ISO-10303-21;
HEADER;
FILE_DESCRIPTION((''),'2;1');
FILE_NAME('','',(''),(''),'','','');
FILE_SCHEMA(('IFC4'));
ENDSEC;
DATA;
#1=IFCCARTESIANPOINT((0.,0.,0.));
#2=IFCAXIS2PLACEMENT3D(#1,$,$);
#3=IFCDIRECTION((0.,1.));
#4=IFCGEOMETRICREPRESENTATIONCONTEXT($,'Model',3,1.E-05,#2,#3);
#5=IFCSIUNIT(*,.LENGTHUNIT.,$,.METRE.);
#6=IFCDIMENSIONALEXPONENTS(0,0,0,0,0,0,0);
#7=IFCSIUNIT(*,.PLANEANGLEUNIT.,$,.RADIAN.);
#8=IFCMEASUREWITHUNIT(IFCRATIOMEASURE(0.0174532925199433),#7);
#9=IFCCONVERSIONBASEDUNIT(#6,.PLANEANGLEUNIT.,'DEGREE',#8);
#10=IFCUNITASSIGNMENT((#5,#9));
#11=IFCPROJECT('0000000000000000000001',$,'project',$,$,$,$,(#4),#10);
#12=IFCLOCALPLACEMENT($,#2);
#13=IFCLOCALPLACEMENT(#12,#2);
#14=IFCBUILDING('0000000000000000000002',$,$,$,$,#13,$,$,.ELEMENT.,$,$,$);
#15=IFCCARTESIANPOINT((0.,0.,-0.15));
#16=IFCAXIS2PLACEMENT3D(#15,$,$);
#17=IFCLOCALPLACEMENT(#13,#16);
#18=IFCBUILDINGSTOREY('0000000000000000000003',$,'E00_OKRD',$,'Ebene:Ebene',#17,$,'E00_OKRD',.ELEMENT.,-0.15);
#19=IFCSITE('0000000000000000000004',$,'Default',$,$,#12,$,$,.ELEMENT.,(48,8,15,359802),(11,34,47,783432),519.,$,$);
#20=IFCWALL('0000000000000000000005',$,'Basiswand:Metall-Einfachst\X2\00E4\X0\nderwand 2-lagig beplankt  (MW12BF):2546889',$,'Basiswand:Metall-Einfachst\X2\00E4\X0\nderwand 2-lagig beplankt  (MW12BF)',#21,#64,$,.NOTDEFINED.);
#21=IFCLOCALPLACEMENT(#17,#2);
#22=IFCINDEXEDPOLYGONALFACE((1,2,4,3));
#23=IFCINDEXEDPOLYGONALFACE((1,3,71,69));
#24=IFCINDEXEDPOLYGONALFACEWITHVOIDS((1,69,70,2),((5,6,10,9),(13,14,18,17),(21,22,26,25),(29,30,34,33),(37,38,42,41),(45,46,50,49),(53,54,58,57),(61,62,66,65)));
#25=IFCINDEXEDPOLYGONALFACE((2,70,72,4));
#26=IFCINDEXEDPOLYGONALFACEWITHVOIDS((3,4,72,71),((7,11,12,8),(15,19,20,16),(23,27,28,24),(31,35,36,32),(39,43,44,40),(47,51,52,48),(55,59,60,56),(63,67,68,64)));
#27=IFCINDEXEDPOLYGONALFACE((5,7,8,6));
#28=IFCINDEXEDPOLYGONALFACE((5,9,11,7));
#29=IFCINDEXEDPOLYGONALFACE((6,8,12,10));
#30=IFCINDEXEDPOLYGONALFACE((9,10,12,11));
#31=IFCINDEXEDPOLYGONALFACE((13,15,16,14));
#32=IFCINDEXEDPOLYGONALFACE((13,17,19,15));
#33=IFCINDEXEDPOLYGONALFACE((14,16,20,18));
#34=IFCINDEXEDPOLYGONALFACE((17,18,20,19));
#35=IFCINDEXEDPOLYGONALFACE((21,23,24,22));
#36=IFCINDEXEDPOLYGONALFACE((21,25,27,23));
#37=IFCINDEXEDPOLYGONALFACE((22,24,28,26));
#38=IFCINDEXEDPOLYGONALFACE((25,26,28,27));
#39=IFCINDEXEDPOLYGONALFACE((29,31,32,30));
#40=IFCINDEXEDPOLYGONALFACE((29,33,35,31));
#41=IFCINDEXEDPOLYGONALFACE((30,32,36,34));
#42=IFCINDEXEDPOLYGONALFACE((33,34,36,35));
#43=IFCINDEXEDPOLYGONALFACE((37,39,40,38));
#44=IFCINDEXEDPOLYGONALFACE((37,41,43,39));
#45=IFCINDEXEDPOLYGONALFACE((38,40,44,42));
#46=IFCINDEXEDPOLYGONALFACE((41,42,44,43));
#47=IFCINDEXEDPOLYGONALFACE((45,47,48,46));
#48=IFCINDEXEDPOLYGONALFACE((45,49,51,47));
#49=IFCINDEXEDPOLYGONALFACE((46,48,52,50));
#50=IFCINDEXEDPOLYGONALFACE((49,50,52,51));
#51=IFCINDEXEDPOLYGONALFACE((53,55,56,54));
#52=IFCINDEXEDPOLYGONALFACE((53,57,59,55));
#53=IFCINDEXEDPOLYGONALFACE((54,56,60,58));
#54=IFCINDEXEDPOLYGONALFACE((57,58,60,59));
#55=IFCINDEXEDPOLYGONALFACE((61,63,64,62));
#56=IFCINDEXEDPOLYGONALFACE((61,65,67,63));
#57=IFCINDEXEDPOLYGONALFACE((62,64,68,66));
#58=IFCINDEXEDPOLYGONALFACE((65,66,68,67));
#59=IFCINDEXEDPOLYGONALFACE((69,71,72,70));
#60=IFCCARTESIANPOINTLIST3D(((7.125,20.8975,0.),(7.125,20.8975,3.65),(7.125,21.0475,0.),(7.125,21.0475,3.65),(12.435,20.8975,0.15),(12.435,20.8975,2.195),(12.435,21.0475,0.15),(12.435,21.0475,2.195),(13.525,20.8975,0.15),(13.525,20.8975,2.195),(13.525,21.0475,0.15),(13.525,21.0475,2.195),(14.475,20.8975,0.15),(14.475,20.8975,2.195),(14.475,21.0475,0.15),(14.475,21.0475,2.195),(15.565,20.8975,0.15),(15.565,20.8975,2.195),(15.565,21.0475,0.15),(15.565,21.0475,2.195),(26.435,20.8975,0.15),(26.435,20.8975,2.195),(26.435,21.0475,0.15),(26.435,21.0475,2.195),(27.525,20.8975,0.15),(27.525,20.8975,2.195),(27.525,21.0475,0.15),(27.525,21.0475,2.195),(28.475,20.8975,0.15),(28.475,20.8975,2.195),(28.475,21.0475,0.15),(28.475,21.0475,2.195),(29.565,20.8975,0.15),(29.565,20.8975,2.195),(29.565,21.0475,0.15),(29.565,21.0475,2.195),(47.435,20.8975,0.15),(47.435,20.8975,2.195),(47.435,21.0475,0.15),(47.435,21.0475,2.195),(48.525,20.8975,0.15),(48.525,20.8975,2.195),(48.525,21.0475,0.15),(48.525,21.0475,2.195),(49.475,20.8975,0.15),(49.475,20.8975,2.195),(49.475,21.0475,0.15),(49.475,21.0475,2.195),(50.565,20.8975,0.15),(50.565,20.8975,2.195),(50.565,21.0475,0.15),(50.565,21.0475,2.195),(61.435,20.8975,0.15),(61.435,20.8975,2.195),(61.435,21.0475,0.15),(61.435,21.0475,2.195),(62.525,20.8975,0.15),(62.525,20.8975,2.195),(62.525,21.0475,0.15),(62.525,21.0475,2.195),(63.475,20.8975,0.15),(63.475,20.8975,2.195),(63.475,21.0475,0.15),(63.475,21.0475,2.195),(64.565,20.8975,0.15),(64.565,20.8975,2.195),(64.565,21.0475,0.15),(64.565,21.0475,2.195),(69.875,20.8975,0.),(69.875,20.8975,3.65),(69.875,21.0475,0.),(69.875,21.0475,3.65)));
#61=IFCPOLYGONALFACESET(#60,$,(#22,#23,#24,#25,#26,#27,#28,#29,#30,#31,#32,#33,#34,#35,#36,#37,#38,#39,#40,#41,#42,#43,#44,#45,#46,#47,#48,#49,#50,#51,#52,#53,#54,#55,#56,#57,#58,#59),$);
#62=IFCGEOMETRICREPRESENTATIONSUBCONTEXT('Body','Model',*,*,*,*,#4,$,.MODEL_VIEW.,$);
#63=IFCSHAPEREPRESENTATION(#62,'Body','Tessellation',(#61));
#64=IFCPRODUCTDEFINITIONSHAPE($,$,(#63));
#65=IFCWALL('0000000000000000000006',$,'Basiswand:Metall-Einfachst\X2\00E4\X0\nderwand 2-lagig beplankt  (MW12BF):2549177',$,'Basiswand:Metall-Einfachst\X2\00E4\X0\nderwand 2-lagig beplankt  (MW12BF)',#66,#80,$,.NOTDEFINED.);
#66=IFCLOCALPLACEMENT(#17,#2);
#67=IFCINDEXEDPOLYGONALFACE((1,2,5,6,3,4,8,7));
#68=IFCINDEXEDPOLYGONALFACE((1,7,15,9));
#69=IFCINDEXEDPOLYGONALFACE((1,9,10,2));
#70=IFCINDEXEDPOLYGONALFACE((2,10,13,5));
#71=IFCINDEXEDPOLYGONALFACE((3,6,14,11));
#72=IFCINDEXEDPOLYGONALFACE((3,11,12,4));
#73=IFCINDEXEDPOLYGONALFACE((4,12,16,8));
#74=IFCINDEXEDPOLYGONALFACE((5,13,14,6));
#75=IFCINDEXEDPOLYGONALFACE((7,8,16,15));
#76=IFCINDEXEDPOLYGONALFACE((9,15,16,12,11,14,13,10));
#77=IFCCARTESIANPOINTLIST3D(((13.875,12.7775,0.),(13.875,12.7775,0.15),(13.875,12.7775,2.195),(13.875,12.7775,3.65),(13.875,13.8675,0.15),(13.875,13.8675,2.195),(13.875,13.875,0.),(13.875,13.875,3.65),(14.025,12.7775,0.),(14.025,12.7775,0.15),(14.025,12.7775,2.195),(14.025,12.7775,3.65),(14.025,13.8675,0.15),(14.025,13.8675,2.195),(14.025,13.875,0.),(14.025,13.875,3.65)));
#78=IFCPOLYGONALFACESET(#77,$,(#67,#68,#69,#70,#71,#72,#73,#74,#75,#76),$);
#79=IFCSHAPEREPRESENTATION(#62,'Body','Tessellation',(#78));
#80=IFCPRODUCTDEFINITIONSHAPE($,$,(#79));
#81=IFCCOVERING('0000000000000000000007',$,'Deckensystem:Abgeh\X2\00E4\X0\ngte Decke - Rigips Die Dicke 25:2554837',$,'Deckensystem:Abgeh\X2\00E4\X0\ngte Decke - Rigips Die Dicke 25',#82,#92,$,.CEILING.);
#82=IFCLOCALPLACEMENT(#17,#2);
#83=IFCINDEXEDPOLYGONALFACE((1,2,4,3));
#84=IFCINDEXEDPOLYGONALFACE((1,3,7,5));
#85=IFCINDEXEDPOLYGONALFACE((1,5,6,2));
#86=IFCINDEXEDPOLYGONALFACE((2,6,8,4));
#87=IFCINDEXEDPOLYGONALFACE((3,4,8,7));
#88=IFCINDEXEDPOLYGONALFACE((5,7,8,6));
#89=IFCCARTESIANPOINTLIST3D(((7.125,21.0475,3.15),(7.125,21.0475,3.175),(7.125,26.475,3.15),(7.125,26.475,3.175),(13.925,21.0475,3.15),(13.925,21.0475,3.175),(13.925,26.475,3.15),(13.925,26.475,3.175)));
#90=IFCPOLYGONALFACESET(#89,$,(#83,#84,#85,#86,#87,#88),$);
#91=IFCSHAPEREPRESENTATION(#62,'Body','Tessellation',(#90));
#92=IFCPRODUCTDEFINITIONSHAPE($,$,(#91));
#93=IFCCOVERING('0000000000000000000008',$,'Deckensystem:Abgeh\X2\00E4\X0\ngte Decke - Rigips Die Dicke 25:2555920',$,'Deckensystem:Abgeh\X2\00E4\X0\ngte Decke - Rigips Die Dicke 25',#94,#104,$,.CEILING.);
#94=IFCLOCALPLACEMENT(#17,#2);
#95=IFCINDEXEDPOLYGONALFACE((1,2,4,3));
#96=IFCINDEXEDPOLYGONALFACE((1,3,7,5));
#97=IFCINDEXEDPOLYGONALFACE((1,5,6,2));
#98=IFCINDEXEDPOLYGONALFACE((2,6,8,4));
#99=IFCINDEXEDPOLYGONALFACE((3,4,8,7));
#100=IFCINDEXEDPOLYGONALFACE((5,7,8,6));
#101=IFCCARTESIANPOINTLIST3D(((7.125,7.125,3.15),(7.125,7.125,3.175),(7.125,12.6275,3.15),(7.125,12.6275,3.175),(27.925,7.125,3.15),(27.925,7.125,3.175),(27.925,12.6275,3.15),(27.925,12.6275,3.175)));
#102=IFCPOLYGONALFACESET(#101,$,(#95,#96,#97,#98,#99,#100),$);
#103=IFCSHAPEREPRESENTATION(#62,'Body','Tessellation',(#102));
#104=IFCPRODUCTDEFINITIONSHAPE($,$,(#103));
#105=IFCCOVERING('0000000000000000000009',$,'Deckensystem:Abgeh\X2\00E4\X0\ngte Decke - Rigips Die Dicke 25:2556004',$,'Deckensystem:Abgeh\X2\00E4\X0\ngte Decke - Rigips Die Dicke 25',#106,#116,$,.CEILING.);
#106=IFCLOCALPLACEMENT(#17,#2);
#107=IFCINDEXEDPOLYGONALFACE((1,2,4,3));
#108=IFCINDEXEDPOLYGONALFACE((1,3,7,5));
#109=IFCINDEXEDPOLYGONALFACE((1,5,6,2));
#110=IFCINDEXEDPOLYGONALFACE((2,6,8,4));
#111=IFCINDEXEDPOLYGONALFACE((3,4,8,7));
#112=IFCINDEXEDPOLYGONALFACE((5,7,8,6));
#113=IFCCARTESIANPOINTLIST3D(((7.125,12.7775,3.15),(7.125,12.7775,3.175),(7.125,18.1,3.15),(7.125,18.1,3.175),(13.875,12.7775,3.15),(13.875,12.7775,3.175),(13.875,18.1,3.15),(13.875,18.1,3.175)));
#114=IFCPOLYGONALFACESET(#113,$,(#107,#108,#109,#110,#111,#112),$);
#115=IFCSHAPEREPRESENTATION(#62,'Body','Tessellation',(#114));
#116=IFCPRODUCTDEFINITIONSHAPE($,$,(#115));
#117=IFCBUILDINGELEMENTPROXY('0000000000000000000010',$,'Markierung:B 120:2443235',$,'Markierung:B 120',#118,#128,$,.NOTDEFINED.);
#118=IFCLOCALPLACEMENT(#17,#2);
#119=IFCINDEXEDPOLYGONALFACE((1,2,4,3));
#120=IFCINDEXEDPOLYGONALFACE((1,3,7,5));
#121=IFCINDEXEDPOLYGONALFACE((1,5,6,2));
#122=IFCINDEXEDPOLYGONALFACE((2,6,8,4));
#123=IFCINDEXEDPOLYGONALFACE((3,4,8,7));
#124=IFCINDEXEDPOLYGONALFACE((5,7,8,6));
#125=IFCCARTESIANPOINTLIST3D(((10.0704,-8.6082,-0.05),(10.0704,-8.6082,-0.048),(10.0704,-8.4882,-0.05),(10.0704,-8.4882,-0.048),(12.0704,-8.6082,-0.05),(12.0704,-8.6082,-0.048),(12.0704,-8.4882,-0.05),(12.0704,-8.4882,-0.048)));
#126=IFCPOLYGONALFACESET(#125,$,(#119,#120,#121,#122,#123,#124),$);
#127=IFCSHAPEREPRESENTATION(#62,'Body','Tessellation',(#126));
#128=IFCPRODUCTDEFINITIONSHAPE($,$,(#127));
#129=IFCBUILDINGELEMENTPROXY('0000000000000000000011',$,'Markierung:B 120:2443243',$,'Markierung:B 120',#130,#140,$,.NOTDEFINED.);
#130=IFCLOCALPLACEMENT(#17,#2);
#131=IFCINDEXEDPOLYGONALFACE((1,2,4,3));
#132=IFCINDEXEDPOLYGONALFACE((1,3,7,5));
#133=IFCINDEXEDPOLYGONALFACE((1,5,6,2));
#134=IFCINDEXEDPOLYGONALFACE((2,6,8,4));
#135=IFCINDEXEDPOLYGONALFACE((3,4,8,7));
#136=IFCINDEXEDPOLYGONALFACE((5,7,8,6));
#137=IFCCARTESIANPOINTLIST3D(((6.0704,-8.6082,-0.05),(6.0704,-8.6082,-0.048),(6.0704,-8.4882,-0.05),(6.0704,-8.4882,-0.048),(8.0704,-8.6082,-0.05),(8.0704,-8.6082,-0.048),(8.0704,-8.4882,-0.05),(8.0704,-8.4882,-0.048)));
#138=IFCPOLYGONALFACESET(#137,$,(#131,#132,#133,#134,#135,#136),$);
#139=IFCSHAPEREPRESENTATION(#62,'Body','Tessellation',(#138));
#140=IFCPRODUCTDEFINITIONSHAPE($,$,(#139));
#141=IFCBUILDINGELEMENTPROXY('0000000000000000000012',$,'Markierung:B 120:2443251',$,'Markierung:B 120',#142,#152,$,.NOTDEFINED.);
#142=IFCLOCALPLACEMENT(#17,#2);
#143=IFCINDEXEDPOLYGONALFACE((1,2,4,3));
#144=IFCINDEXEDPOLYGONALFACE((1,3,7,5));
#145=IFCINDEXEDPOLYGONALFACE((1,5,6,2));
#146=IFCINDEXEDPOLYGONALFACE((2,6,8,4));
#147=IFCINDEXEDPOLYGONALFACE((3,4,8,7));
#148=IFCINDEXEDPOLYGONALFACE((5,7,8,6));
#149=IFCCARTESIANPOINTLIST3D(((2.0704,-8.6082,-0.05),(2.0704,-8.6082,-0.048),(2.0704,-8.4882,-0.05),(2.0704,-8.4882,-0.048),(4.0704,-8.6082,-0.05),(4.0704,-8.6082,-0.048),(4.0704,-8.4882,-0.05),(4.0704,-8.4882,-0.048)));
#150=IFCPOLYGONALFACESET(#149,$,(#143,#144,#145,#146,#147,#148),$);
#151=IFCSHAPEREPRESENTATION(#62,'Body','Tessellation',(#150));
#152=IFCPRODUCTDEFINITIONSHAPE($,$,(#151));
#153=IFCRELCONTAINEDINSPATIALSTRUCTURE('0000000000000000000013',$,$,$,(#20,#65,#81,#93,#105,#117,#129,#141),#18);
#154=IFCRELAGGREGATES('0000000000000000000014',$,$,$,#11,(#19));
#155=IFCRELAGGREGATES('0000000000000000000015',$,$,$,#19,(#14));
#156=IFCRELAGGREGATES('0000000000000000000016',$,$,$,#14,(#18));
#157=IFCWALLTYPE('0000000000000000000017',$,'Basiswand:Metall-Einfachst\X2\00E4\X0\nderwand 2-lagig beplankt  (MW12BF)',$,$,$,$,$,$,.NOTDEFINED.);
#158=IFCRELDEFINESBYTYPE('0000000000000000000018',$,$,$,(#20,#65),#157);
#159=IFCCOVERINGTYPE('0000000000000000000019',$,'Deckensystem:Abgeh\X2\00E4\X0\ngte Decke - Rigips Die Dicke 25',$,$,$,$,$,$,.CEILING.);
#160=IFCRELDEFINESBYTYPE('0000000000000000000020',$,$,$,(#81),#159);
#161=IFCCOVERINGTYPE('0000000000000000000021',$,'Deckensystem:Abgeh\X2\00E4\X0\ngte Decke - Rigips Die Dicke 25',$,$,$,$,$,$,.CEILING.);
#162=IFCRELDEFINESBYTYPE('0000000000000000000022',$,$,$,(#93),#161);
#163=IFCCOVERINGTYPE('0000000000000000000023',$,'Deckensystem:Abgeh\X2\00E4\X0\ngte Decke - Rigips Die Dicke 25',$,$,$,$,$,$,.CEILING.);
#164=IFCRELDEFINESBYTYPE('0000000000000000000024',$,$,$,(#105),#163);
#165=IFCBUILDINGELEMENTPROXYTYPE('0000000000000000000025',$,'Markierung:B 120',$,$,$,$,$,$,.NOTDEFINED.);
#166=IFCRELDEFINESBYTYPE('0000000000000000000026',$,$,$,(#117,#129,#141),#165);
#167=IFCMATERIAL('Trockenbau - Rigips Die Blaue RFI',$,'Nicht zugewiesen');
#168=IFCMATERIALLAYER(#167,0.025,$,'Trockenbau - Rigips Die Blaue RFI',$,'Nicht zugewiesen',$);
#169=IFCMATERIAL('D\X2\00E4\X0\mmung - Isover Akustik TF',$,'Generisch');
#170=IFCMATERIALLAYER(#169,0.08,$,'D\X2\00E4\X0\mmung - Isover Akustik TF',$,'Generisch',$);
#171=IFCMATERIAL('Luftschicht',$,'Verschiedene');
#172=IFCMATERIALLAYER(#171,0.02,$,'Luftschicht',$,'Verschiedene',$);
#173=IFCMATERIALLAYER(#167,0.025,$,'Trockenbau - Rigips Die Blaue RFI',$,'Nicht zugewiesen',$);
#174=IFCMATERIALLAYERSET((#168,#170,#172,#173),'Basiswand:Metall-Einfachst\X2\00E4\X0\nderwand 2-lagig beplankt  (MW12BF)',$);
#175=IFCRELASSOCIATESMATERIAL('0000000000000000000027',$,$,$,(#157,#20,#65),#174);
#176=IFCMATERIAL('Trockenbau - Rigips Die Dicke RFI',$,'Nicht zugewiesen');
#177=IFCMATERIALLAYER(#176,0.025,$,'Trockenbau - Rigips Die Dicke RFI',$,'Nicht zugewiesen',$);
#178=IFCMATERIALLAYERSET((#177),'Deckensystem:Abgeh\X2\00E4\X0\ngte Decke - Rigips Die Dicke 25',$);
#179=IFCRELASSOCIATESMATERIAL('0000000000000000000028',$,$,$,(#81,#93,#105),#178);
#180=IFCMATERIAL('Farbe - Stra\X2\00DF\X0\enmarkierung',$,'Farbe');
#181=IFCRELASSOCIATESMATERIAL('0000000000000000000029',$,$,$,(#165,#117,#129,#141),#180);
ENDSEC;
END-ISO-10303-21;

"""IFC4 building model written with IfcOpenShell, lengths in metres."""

from ifc_helpers import new_model, entity, si_unit, converted_unit, direction, frame, frame_2d, origin, place, context, subcontext, project, spatial, rectangle, extrude, source, transform, mapped, material, layer, layer_set, layer_usage, type_object, type_shapes, element, save


model = new_model("IFC4")

# Units and contexts
model_context = context("Model", 3, precision=1e-05, world=origin(), true_north=direction((0.0, 1.0)))
body_context = subcontext(model_context, "Body", "Model", "MODEL_VIEW")
ifc_project = project(units=[si_unit("LENGTHUNIT", "METRE"), converted_unit("PLANEANGLEUNIT", "DEGREE", entity("IfcRatioMeasure", 0.0174532925199433), si_unit("PLANEANGLEUNIT", "RADIAN"), dimensions=[0, 0, 0, 0, 0, 0, 0])], contexts=[model_context])

# Site, building, storey
site_placement = place(None, frame((0.0, 0.0, 0.0)))
site = spatial("IfcSite", under=ifc_project, at=site_placement, Name="Default", CompositionType="ELEMENT", RefLatitude=(48, 8, 15, 359802), RefLongitude=(11, 34, 47, 783432), RefElevation=519.0)
building_placement = place(site_placement, origin())
building = spatial("IfcBuilding", under=site, at=building_placement, CompositionType="ELEMENT")
storey_placement = place(building_placement, frame((0.0, 0.0, -0.15)))
storey = spatial("IfcBuildingStorey", under=building, at=storey_placement, Name="E00_OKRD", ObjectType="Ebene:Ebene", LongName="E00_OKRD", CompositionType="ELEMENT", Elevation=-0.15)

# Wall, openings
ifc_material_1 = material(Name="Trockenbau - Rigips Die Blaue RFI", Category="Nicht zugewiesen")
ifc_layer_1 = layer(ifc_material_1, 0.025, Name="Trockenbau - Rigips Die Blaue RFI", Category="Nicht zugewiesen")
ifc_material_2 = material(Name="Dämmung - Isover Akustik TF", Category="Generisch")
ifc_layer_2 = layer(ifc_material_2, 0.08, Name="Dämmung - Isover Akustik TF", Category="Generisch")
ifc_material_3 = material(Name="Luftschicht", Category="Verschiedene")
ifc_layer_3 = layer(ifc_material_3, 0.02, Name="Luftschicht", Category="Verschiedene")
ifc_layer_4 = layer(ifc_material_1, 0.025, Name="Trockenbau - Rigips Die Blaue RFI", Category="Nicht zugewiesen")
ifc_layer_set_1 = layer_set([ifc_layer_1, ifc_layer_2, ifc_layer_3, ifc_layer_4], Name="Basiswand:Metall-Einfachständerwand 2-lagig beplankt  (MW12BF)")
ifc_layer_usage_1 = layer_usage(ifc_layer_set_1, "AXIS2", "POSITIVE", -0.075)
wall_type_1 = type_object("IfcWallType", Name="Basiswand:Metall-Einfachständerwand 2-lagig beplankt  (MW12BF)", PredefinedType="NOTDEFINED", material=ifc_layer_set_1)
wall_1_placement = place(storey_placement, frame((7.125, 20.9725, 0.0)))
wall_1 = element("IfcWall", 1, at=wall_1_placement, inside=storey, type_object=wall_type_1, material=ifc_layer_usage_1, Name="Basiswand:Metall-Einfachständerwand 2-lagig beplankt  (MW12BF):2546889", ObjectType="Basiswand:Metall-Einfachständerwand 2-lagig beplankt  (MW12BF)", PredefinedType="NOTDEFINED", context=body_context, shape_type="SweptSolid", body=[
    extrude(rectangle(XDim=62.75, YDim=0.15, at=frame_2d((31.375, 0.0), x_axis=(-1.0, 0.0))), origin(), (0.0, 0.0, 1.0), 3.65),
])
opening_1_placement = place(wall_1_placement, frame((40.31, -0.075, 0.15)))
element("IfcOpeningElement", 2, at=opening_1_placement, cuts=wall_1, ObjectType="Opening", PredefinedType="OPENING", context=body_context, shape_type="SweptSolid", body=[
    extrude(rectangle(XDim=2.045, YDim=1.09, at=frame_2d((1.0225, 0.545), x_axis=(-1.0, 0.0))), frame((0.0, 0.0, 0.0), z_axis=(0.0, 1.0, 0.0), x_axis=(0.0, 0.0, 1.0)), (0.0, 0.0, 1.0), 0.15),
])
opening_2_placement = place(wall_1_placement, frame((42.35, -0.075, 0.15)))
element("IfcOpeningElement", 3, at=opening_2_placement, cuts=wall_1, ObjectType="Opening", PredefinedType="OPENING", context=body_context, shape_type="SweptSolid", body=[
    extrude(rectangle(XDim=2.045, YDim=1.09, at=frame_2d((1.0225, 0.545), x_axis=(-1.0, 0.0))), frame((0.0, 0.0, 0.0), z_axis=(0.0, 1.0, 0.0), x_axis=(0.0, 0.0, 1.0)), (0.0, 0.0, 1.0), 0.15),
])
opening_3_placement = place(wall_1_placement, frame((54.31, -0.075, 0.15)))
element("IfcOpeningElement", 4, at=opening_3_placement, cuts=wall_1, ObjectType="Opening", PredefinedType="OPENING", context=body_context, shape_type="SweptSolid", body=[
    extrude(rectangle(XDim=2.045, YDim=1.09, at=frame_2d((1.0225, 0.545), x_axis=(-1.0, 0.0))), frame((0.0, 0.0, 0.0), z_axis=(0.0, 1.0, 0.0), x_axis=(0.0, 0.0, 1.0)), (0.0, 0.0, 1.0), 0.15),
])
opening_4_placement = place(wall_1_placement, frame((56.35, -0.075, 0.15)))
element("IfcOpeningElement", 5, at=opening_4_placement, cuts=wall_1, ObjectType="Opening", PredefinedType="OPENING", context=body_context, shape_type="SweptSolid", body=[
    extrude(rectangle(XDim=2.045, YDim=1.09, at=frame_2d((1.0225, 0.545), x_axis=(-1.0, 0.0))), frame((0.0, 0.0, 0.0), z_axis=(0.0, 1.0, 0.0), x_axis=(0.0, 0.0, 1.0)), (0.0, 0.0, 1.0), 0.15),
])
opening_5_placement = place(wall_1_placement, frame((5.31, -0.075, 0.15)))
element("IfcOpeningElement", 6, at=opening_5_placement, cuts=wall_1, ObjectType="Opening", PredefinedType="OPENING", context=body_context, shape_type="SweptSolid", body=[
    extrude(rectangle(XDim=2.045, YDim=1.09, at=frame_2d((1.0225, 0.545), x_axis=(-1.0, 0.0))), frame((0.0, 0.0, 0.0), z_axis=(0.0, 1.0, 0.0), x_axis=(0.0, 0.0, 1.0)), (0.0, 0.0, 1.0), 0.15),
])
opening_6_placement = place(wall_1_placement, frame((7.35, -0.075, 0.15)))
element("IfcOpeningElement", 7, at=opening_6_placement, cuts=wall_1, ObjectType="Opening", PredefinedType="OPENING", context=body_context, shape_type="SweptSolid", body=[
    extrude(rectangle(XDim=2.045, YDim=1.09, at=frame_2d((1.0225, 0.545), x_axis=(-1.0, 0.0))), frame((0.0, 0.0, 0.0), z_axis=(0.0, 1.0, 0.0), x_axis=(0.0, 0.0, 1.0)), (0.0, 0.0, 1.0), 0.15),
])
opening_7_placement = place(wall_1_placement, frame((19.31, -0.075, 0.15)))
element("IfcOpeningElement", 8, at=opening_7_placement, cuts=wall_1, ObjectType="Opening", PredefinedType="OPENING", context=body_context, shape_type="SweptSolid", body=[
    extrude(rectangle(XDim=2.045, YDim=1.09, at=frame_2d((1.0225, 0.545), x_axis=(-1.0, 0.0))), frame((0.0, 0.0, 0.0), z_axis=(0.0, 1.0, 0.0), x_axis=(0.0, 0.0, 1.0)), (0.0, 0.0, 1.0), 0.15),
])
opening_8_placement = place(wall_1_placement, frame((21.35, -0.075, 0.15)))
element("IfcOpeningElement", 9, at=opening_8_placement, cuts=wall_1, ObjectType="Opening", PredefinedType="OPENING", context=body_context, shape_type="SweptSolid", body=[
    extrude(rectangle(XDim=2.045, YDim=1.09, at=frame_2d((1.0225, 0.545), x_axis=(-1.0, 0.0))), frame((0.0, 0.0, 0.0), z_axis=(0.0, 1.0, 0.0), x_axis=(0.0, 0.0, 1.0)), (0.0, 0.0, 1.0), 0.15),
])

# Wall, opening
ifc_layer_usage_2 = layer_usage(ifc_layer_set_1, "AXIS2", "POSITIVE", -0.075)
wall_2_placement = place(storey_placement, frame((13.95, 13.875, 0.0), z_axis=(0.0, 0.0, 1.0), x_axis=(0.0, -1.0, 0.0)))
wall_2 = element("IfcWall", 10, at=wall_2_placement, inside=storey, type_object=wall_type_1, material=ifc_layer_usage_2, Name="Basiswand:Metall-Einfachständerwand 2-lagig beplankt  (MW12BF):2549177", ObjectType="Basiswand:Metall-Einfachständerwand 2-lagig beplankt  (MW12BF)", PredefinedType="NOTDEFINED", context=body_context, shape_type="SweptSolid", body=[
    extrude(rectangle(XDim=1.0975, YDim=0.15, at=frame_2d((0.5487, 0.0), x_axis=(-1.0, 0.0))), origin(), (0.0, 0.0, 1.0), 3.65),
])
opening_9_placement = place(wall_2_placement, frame((1.0975, 0.075, 0.15)))
element("IfcOpeningElement", 11, at=opening_9_placement, cuts=wall_2, ObjectType="Opening", PredefinedType="OPENING", context=body_context, shape_type="SweptSolid", body=[
    extrude(rectangle(XDim=2.045, YDim=1.09, at=frame_2d((1.0225, 0.545), x_axis=(-1.0, 0.0))), frame((0.0, 0.0, 0.0), z_axis=(0.0, -1.0, 0.0), x_axis=(0.0, 0.0, 1.0)), (0.0, 0.0, 1.0), 0.15),
])

# Coverings
ifc_material_4 = material(Name="Trockenbau - Rigips Die Dicke RFI", Category="Nicht zugewiesen")
ifc_layer_5 = layer(ifc_material_4, 0.025, Name="Trockenbau - Rigips Die Dicke RFI", Category="Nicht zugewiesen")
ifc_layer_set_2 = layer_set([ifc_layer_5], Name="Deckensystem:Abgehängte Decke - Rigips Die Dicke 25")
ifc_layer_usage_3 = layer_usage(ifc_layer_set_2, "AXIS3", "POSITIVE", 0.0)
covering_type_1 = type_object("IfcCoveringType", Name="Deckensystem:Abgehängte Decke - Rigips Die Dicke 25", PredefinedType="CEILING")
covering_1_placement = place(storey_placement, frame((7.125, 21.0475, 3.15)))
element("IfcCovering", 12, at=covering_1_placement, inside=storey, type_object=covering_type_1, material=ifc_layer_usage_3, Name="Deckensystem:Abgehängte Decke - Rigips Die Dicke 25:2554837", ObjectType="Deckensystem:Abgehängte Decke - Rigips Die Dicke 25", PredefinedType="CEILING", context=body_context, shape_type="SweptSolid", body=[
    extrude(rectangle(XDim=6.8, YDim=5.4275, at=frame_2d((0.0, 0.0), x_axis=(1.0, 0.0))), frame((3.4, 2.7137, 0.0), z_axis=(0.0, 0.0, 1.0), x_axis=(-1.0, 0.0, 0.0)), (0.0, 0.0, 1.0), 0.025),
])
ifc_layer_usage_4 = layer_usage(ifc_layer_set_2, "AXIS3", "POSITIVE", 0.0)
covering_type_2 = type_object("IfcCoveringType", Name="Deckensystem:Abgehängte Decke - Rigips Die Dicke 25", PredefinedType="CEILING")
covering_2_placement = place(storey_placement, frame((7.125, 7.125, 3.15)))
element("IfcCovering", 13, at=covering_2_placement, inside=storey, type_object=covering_type_2, material=ifc_layer_usage_4, Name="Deckensystem:Abgehängte Decke - Rigips Die Dicke 25:2555920", ObjectType="Deckensystem:Abgehängte Decke - Rigips Die Dicke 25", PredefinedType="CEILING", context=body_context, shape_type="SweptSolid", body=[
    extrude(rectangle(XDim=20.8, YDim=5.5025, at=frame_2d((0.0, 0.0), x_axis=(1.0, 0.0))), frame((10.4, 2.7513, 0.0), z_axis=(0.0, 0.0, 1.0), x_axis=(-1.0, 0.0, 0.0)), (0.0, 0.0, 1.0), 0.025),
])
ifc_layer_usage_5 = layer_usage(ifc_layer_set_2, "AXIS3", "POSITIVE", 0.0)
covering_type_3 = type_object("IfcCoveringType", Name="Deckensystem:Abgehängte Decke - Rigips Die Dicke 25", PredefinedType="CEILING")
covering_3_placement = place(storey_placement, frame((7.125, 12.7775, 3.15)))
element("IfcCovering", 14, at=covering_3_placement, inside=storey, type_object=covering_type_3, material=ifc_layer_usage_5, Name="Deckensystem:Abgehängte Decke - Rigips Die Dicke 25:2556004", ObjectType="Deckensystem:Abgehängte Decke - Rigips Die Dicke 25", PredefinedType="CEILING", context=body_context, shape_type="SweptSolid", body=[
    extrude(rectangle(XDim=6.75, YDim=5.3225, at=frame_2d((0.0, 0.0), x_axis=(1.0, 0.0))), frame((3.375, 2.6613, 0.0), z_axis=(0.0, 0.0, 1.0), x_axis=(-1.0, 0.0, 0.0)), (0.0, 0.0, 1.0), 0.025),
])

# Building element proxies
ifc_material_5 = material(Name="Farbe - Straßenmarkierung", Category="Farbe")
building_element_proxy_type = type_object("IfcBuildingElementProxyType", Name="Markierung:B 120", PredefinedType="NOTDEFINED", material=ifc_material_5)
shared_shape_1 = source(origin(), body_context, "Body", "SweptSolid", [
    extrude(rectangle(XDim=0.12, YDim=2.0, at=frame_2d((0.0, 0.0), x_axis=(1.0, 0.0))), frame((0.06, 1.0, 0.0), z_axis=(0.0, 0.0, 1.0), x_axis=(-1.0, 0.0, 0.0)), (0.0, 0.0, 1.0), 0.002),
])
type_shapes(building_element_proxy_type, [shared_shape_1])
for number, where, z_axis, x_axis, name in (
    (15, (12.0704, -8.6082, -0.05), (0.0, 0.0, 1.0), (0.0, 1.0, 0.0), "Markierung:B 120:2443235"),
    (16, (8.0704, -8.6082, -0.05), (0.0, 0.0, 1.0), (0.0, 1.0, 0.0), "Markierung:B 120:2443243"),
    (17, (4.0704, -8.6082, -0.05), (0.0, 0.0, 1.0), (0.0, 1.0, 0.0), "Markierung:B 120:2443251"),
):
    element("IfcBuildingElementProxy", number, at=place(storey_placement, frame(where, z_axis=z_axis, x_axis=x_axis)), inside=storey, type_object=building_element_proxy_type, material=ifc_material_5, Name=name, ObjectType="Markierung:B 120", PredefinedType="NOTDEFINED", context=body_context, shape_type="MappedRepresentation", body=[
        mapped(shared_shape_1, transform((0.0, 0.0, 0.0), scale=1.0)),
    ])

save(model, "model.ifc")
